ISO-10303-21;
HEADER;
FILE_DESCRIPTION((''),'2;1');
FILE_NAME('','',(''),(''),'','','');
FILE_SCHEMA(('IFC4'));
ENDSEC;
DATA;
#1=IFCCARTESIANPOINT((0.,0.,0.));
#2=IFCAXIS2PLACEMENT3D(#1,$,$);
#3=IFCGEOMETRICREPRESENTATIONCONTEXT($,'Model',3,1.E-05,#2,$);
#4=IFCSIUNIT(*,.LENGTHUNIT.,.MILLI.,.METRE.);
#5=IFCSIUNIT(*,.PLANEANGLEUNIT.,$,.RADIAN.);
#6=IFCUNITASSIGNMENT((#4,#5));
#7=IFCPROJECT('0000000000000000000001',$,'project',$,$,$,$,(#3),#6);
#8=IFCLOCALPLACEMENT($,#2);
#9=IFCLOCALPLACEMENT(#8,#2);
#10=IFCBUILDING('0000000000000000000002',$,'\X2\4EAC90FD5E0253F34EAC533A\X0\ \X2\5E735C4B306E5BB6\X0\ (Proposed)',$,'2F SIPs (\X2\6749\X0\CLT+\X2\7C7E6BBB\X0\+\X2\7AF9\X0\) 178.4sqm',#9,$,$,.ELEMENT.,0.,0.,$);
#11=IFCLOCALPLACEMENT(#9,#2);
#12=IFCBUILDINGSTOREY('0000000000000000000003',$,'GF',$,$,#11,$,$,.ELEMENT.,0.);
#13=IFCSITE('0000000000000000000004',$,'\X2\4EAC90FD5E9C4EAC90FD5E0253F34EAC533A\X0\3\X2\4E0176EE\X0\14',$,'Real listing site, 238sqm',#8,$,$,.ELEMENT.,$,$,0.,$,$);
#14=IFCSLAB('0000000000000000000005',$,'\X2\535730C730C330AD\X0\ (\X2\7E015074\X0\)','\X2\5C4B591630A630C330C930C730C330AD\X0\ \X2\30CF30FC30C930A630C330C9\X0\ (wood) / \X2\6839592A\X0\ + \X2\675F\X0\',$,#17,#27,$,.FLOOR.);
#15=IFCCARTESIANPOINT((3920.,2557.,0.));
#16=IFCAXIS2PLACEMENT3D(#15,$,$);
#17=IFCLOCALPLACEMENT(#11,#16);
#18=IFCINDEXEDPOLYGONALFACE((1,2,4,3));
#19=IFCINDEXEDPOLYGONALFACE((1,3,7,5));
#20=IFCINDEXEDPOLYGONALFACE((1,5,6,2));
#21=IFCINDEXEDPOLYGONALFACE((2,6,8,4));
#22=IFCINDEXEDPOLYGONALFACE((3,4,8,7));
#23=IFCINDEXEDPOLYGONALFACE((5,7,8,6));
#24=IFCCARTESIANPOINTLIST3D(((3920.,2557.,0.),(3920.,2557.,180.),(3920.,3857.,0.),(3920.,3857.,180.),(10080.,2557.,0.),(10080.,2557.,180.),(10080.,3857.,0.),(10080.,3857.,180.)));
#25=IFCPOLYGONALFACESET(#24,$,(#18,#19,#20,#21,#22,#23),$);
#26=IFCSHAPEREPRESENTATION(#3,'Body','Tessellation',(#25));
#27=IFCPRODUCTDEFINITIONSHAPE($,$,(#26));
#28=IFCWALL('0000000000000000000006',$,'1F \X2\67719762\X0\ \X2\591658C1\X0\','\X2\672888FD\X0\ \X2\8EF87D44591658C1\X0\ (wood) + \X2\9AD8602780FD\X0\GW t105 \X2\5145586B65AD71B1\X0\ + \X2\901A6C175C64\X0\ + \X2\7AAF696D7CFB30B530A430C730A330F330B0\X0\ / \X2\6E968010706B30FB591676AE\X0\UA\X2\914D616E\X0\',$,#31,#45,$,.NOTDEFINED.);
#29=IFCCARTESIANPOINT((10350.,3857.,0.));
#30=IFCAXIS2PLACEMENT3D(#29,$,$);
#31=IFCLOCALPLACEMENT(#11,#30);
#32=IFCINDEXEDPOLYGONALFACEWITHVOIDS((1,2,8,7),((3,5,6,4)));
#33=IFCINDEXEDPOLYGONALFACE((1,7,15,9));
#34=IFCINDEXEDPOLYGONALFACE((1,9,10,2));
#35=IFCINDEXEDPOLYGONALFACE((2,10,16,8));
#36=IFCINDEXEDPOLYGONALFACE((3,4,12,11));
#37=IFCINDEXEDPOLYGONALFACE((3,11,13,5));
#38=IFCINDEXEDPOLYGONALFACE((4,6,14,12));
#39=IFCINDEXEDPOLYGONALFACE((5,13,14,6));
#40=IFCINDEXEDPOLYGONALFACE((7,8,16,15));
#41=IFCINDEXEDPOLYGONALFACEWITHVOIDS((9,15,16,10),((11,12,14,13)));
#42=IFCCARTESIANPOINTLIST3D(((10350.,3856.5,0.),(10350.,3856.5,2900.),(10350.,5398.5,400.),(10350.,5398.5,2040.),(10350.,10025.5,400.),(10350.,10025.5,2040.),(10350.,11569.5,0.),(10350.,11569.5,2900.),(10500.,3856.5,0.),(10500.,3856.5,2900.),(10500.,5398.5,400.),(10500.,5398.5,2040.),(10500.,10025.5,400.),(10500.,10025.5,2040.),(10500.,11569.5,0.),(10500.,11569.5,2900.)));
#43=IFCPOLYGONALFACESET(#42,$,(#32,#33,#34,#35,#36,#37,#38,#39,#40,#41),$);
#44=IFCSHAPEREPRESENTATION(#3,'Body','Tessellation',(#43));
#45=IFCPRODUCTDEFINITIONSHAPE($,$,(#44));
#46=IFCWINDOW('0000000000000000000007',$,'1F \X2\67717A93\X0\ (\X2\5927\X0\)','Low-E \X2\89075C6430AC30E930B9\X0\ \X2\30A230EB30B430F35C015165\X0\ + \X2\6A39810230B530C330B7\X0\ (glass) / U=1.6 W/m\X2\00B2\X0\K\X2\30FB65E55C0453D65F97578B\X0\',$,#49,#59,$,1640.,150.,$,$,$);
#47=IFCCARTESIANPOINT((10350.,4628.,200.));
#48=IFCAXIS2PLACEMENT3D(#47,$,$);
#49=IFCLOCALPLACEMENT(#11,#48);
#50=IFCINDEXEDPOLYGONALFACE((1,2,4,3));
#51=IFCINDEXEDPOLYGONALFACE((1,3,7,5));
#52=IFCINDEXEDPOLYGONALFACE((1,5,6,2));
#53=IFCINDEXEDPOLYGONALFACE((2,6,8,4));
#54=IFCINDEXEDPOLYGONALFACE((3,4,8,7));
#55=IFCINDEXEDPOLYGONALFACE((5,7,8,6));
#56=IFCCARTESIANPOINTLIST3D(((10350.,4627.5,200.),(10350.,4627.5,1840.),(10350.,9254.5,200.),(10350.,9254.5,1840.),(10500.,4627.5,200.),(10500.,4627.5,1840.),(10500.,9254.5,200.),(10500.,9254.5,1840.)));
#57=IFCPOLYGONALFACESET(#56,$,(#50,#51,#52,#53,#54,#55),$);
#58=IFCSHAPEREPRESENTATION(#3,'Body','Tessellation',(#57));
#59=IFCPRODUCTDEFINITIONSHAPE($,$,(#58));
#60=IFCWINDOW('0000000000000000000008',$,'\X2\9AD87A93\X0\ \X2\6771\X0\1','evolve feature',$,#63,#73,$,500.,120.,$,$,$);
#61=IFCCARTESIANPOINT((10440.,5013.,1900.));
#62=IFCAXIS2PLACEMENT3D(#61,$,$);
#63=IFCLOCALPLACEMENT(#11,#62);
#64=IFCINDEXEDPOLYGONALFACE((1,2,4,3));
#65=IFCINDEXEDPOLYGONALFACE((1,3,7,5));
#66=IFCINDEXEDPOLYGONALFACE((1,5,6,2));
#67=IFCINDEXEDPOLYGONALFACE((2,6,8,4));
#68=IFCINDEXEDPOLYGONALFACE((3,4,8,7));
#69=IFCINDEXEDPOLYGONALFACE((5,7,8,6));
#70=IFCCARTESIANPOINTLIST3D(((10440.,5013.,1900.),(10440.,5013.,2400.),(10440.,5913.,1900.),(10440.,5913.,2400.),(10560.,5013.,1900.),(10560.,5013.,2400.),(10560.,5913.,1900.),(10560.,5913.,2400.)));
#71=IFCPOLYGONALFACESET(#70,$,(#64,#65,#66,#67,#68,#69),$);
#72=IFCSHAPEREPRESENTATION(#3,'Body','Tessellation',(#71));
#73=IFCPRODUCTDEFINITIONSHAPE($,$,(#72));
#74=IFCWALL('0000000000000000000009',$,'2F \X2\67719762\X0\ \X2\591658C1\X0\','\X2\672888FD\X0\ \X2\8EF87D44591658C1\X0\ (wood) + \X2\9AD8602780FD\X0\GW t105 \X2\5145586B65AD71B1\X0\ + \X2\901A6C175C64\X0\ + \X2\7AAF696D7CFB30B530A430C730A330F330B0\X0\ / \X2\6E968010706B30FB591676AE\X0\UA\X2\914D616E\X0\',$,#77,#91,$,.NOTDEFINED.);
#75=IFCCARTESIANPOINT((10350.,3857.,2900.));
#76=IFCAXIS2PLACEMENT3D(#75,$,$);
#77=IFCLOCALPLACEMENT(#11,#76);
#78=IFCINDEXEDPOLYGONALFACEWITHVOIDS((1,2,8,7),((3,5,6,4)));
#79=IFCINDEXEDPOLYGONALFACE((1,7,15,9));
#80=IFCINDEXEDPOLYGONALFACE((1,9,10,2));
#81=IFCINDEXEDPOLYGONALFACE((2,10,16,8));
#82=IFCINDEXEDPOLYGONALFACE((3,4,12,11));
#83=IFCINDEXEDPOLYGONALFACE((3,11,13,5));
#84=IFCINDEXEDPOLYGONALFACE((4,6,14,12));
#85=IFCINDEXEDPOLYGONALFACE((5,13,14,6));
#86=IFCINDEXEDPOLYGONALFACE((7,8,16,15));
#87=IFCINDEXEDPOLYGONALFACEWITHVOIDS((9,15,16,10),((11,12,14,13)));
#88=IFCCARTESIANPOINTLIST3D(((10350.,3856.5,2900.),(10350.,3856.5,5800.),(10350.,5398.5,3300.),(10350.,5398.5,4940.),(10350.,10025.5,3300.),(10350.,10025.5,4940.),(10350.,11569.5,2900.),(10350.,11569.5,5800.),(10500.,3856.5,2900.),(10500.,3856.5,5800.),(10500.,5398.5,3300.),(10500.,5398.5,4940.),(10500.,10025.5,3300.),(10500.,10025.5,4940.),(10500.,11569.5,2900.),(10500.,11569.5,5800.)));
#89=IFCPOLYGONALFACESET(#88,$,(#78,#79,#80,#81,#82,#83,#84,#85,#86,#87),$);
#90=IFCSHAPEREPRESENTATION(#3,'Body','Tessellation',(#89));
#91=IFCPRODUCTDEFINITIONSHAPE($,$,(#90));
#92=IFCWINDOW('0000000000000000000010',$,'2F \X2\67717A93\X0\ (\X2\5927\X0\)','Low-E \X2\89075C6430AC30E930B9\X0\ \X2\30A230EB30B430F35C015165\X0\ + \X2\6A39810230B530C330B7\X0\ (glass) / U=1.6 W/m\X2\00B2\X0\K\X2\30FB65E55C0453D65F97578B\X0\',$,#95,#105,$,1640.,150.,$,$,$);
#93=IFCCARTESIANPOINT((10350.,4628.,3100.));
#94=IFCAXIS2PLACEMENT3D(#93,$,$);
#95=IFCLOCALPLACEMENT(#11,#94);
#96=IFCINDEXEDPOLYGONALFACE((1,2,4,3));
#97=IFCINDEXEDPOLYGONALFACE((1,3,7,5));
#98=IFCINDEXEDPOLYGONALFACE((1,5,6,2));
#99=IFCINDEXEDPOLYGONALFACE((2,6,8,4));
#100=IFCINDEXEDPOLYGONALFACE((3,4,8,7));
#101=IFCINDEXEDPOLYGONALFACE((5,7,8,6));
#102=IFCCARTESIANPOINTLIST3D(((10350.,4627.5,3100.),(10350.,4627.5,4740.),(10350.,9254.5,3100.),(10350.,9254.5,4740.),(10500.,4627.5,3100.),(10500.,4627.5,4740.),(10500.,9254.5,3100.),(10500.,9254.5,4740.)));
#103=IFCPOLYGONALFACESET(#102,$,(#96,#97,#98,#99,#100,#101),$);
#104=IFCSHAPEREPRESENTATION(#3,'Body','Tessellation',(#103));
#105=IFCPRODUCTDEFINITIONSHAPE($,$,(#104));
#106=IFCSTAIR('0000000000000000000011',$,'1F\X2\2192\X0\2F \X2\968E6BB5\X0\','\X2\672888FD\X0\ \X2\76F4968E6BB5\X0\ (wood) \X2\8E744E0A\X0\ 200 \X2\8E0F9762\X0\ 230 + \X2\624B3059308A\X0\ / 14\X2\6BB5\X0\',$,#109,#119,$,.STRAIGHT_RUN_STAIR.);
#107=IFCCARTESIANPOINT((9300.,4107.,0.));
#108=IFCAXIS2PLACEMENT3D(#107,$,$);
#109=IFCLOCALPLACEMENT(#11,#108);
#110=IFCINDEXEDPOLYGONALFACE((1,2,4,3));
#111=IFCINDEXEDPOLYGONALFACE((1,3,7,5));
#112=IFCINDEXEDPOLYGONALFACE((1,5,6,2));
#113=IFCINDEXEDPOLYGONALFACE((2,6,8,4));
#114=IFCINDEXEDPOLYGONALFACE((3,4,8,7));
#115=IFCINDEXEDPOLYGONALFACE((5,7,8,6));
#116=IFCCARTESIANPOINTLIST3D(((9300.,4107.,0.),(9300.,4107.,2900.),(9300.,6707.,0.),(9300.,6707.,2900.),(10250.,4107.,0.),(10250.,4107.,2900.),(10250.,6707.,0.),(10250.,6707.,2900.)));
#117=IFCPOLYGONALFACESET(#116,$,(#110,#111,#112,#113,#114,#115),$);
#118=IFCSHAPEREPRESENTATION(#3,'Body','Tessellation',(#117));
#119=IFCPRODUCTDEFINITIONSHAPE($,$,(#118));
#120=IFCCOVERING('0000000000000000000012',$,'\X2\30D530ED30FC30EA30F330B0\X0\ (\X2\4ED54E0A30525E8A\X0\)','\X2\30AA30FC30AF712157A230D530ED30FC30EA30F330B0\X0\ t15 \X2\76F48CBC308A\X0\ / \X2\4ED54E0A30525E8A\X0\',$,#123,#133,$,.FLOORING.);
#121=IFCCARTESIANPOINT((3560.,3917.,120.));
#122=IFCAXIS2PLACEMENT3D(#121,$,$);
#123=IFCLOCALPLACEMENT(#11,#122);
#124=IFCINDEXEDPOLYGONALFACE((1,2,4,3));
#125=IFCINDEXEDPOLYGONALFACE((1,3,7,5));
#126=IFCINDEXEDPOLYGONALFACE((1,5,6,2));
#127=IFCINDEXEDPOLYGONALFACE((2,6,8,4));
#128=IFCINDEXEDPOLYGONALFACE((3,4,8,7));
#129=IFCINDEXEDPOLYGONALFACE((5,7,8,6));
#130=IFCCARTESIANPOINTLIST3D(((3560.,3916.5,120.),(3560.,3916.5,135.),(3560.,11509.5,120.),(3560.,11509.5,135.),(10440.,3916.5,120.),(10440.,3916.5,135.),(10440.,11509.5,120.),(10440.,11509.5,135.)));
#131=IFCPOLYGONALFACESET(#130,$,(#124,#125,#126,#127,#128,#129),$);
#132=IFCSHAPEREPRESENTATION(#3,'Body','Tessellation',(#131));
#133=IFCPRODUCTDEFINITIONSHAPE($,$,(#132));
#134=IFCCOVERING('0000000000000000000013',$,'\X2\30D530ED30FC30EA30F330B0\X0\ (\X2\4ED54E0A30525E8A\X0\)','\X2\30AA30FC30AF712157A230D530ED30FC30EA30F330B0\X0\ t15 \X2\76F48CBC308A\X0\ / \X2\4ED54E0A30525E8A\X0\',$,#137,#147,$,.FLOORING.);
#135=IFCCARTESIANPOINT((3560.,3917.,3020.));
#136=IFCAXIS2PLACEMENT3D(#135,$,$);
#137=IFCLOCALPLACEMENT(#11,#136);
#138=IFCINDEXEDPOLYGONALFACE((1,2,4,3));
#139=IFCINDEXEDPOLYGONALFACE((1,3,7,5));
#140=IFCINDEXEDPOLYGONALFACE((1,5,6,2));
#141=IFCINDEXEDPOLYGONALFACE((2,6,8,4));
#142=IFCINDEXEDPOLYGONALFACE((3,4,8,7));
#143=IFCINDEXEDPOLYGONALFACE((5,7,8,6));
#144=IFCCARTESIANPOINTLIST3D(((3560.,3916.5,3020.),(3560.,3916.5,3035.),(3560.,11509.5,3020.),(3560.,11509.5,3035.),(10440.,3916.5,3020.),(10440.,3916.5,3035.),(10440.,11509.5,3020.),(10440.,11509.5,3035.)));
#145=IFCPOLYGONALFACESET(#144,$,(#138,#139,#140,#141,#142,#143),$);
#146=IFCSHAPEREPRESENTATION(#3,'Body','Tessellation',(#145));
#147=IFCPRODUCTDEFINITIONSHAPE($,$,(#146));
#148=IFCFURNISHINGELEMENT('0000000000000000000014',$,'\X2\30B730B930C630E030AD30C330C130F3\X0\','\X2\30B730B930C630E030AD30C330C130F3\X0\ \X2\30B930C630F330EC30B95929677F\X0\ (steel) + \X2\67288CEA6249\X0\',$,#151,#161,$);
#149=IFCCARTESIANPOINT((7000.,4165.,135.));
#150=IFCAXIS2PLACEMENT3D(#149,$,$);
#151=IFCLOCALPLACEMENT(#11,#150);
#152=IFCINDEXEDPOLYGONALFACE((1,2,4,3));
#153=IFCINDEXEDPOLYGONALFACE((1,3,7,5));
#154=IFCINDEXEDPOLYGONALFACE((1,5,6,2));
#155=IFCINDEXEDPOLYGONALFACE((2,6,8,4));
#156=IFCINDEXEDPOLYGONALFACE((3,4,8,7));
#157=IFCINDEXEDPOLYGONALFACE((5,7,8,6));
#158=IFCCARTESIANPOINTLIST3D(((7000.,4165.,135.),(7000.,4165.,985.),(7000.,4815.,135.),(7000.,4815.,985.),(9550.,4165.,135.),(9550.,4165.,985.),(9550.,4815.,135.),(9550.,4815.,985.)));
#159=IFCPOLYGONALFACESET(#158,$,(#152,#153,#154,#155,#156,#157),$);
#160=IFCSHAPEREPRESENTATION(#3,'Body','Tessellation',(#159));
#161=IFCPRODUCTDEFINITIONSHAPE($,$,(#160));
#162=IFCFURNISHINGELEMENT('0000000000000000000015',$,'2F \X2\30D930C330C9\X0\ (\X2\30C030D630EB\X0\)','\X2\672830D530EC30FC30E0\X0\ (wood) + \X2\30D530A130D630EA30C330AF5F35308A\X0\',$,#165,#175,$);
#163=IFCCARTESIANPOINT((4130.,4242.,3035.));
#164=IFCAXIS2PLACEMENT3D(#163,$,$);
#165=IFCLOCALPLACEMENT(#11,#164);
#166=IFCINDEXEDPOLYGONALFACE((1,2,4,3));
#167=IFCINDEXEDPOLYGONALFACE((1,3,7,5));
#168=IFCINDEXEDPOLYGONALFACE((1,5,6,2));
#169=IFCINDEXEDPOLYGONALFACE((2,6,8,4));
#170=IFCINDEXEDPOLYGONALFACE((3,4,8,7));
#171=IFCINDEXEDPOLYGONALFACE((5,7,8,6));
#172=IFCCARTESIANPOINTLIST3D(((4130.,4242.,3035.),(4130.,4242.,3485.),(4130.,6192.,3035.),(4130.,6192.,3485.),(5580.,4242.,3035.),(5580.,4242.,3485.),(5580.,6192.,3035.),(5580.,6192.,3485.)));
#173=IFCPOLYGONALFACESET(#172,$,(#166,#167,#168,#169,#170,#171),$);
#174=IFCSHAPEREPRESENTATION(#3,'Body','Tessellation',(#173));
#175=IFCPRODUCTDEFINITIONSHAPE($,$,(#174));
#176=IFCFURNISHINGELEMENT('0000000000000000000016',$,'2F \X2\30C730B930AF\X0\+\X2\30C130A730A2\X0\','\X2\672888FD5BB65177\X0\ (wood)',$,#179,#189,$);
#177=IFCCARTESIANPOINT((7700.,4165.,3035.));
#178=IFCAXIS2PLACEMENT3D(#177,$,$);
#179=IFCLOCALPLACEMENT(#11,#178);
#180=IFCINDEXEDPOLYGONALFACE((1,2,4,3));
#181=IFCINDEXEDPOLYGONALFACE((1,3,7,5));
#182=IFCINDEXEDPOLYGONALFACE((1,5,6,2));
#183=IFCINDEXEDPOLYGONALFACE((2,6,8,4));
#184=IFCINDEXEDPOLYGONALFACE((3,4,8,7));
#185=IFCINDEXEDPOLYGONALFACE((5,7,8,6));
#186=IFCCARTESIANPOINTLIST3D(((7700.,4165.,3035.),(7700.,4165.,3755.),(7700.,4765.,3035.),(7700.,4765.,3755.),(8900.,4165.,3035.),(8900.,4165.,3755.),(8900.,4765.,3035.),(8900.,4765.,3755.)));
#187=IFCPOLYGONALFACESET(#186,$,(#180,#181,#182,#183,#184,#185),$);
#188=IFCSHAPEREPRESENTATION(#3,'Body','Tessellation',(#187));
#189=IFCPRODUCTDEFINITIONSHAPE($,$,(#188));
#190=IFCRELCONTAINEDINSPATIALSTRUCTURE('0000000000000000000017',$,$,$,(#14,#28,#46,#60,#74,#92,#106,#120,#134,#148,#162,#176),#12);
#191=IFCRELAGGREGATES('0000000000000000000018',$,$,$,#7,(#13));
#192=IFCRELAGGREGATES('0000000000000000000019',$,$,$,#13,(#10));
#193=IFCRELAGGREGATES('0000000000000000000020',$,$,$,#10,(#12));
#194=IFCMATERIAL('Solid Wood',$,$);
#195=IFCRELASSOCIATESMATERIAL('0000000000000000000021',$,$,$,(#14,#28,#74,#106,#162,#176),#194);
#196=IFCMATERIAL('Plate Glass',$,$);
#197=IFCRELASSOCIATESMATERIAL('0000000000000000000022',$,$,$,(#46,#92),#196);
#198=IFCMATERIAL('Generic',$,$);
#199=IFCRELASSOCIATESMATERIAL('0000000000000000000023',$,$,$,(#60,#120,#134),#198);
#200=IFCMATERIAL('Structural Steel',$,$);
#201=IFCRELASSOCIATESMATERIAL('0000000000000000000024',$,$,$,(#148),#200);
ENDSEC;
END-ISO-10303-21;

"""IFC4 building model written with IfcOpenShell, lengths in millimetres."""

from ifc_helpers import new_model, si_unit, frame, frame_2d, origin, place, context, project, spatial, rectangle, extrude, material, element, fill, save


model = new_model("IFC4")

# Units and contexts
model_context = context("Model", 3, precision=1e-05, world=origin())
ifc_project = project(units=[si_unit("LENGTHUNIT", "METRE", prefix="MILLI"), si_unit("PLANEANGLEUNIT", "RADIAN")], contexts=[model_context])

# Site, building, storey
site_placement = place(None, origin())
site = spatial("IfcSite", under=ifc_project, at=site_placement, Name="京都府京都市右京区3丁目14", ObjectType="Real listing site, 238sqm", CompositionType="ELEMENT", RefElevation=0.0)
building_placement = place(site_placement, origin())
building = spatial("IfcBuilding", under=site, at=building_placement, Name="京都市右京区 平屋の家 (Proposed)", ObjectType="2F SIPs (杉CLT+籾殻+竹) 178.4sqm", CompositionType="ELEMENT", ElevationOfRefHeight=0.0, ElevationOfTerrain=0.0)
storey_placement = place(building_placement, origin())
storey = spatial("IfcBuildingStorey", under=building, at=storey_placement, Name="GF", CompositionType="ELEMENT", Elevation=0.0)

# Slab
ifc_material_1 = material(Name="Solid Wood")
slab_placement = place(storey_placement, frame((3920.0, 2557.0, 0.0)))
element("IfcSlab", 1, at=slab_placement, inside=storey, material=ifc_material_1, Name="南デッキ (縁側)", Description="屋外ウッドデッキ ハードウッド (wood) / 根太 + 束", PredefinedType="FLOOR", context=model_context, shape_type="SweptSolid", body=[
    extrude(rectangle(XDim=6160.0, YDim=1300.0, at=frame_2d((3080.0, 650.0))), frame((3920.0, 2557.0, 0.0)), (0.0, 0.0, 1.0), 180.0),
])

# Wall, openings, windows
wall_1_placement = place(storey_placement, frame((10350.0, 3857.0, 0.0)))
wall_1 = element("IfcWall", 2, at=wall_1_placement, inside=storey, material=ifc_material_1, Name="1F 東面 外壁", Description="木製 軸組外壁 (wood) + 高性能GW t105 充填断熱 + 通気層 + 窯業系サイディング / 準耐火・外皮UA配慮", PredefinedType="NOTDEFINED", context=model_context, shape_type="SweptSolid", body=[
    extrude(rectangle(XDim=150.0, YDim=7713.0, at=frame_2d((75.0, 3856.0))), frame((10350.0, 3857.0, 0.0)), (0.0, 0.0, 1.0), 2900.0),
])
opening_1_placement = place(storey_placement, frame((10350.0, 4628.0, 200.0)))
opening_1 = element("IfcOpeningElement", 3, at=opening_1_placement, cuts=wall_1, PredefinedType="NOTDEFINED", context=model_context, shape_type="SweptSolid", body=[
    extrude(rectangle(XDim=150.0, YDim=4627.0, at=frame_2d((75.0, 2313.0))), frame((10350.0, 4628.0, 200.0)), (0.0, 0.0, 1.0), 1640.0),
])
opening_2_placement = place(storey_placement, frame((10440.0, 5013.0, 1900.0)))
opening_2 = element("IfcOpeningElement", 4, at=opening_2_placement, cuts=wall_1, PredefinedType="NOTDEFINED", context=model_context, shape_type="SweptSolid", body=[
    extrude(rectangle(XDim=120.0, YDim=900.0, at=frame_2d((60.0, 450.0))), frame((10440.0, 5013.0, 1900.0)), (0.0, 0.0, 1.0), 500.0),
])
ifc_material_2 = material(Name="Plate Glass")
window_1_placement = place(storey_placement, frame((10350.0, 4628.0, 200.0)))
window_1 = element("IfcWindow", 5, at=window_1_placement, inside=storey, material=ifc_material_2, Name="1F 東窓 (大)", Description="Low-E 複層ガラス アルゴン封入 + 樹脂サッシ (glass) / U=1.6 W/m²K・日射取得型", OverallHeight=1640.0, OverallWidth=150.0, context=model_context, shape_type="SweptSolid", body=[
    extrude(rectangle(XDim=150.0, YDim=4627.0, at=frame_2d((75.0, 2313.0))), frame((10350.0, 4628.0, 200.0)), (0.0, 0.0, 1.0), 1640.0),
])
fill(opening_1, window_1)
ifc_material_3 = material(Name="Generic")
window_2_placement = place(storey_placement, frame((10440.0, 5013.0, 1900.0)))
window_2 = element("IfcWindow", 6, at=window_2_placement, inside=storey, material=ifc_material_3, Name="高窓 東1", Description="evolve feature", OverallHeight=500.0, OverallWidth=120.0, context=model_context, shape_type="SweptSolid", body=[
    extrude(rectangle(XDim=120.0, YDim=900.0, at=frame_2d((60.0, 450.0))), frame((10440.0, 5013.0, 1900.0)), (0.0, 0.0, 1.0), 500.0),
])
fill(opening_2, window_2)

# Wall, opening, window
wall_2_placement = place(storey_placement, frame((10350.0, 3857.0, 2900.0)))
wall_2 = element("IfcWall", 7, at=wall_2_placement, inside=storey, material=ifc_material_1, Name="2F 東面 外壁", Description="木製 軸組外壁 (wood) + 高性能GW t105 充填断熱 + 通気層 + 窯業系サイディング / 準耐火・外皮UA配慮", PredefinedType="NOTDEFINED", context=model_context, shape_type="SweptSolid", body=[
    extrude(rectangle(XDim=150.0, YDim=7713.0, at=frame_2d((75.0, 3856.0))), frame((10350.0, 3857.0, 2900.0)), (0.0, 0.0, 1.0), 2900.0),
])
opening_3_placement = place(storey_placement, frame((10350.0, 4628.0, 3100.0)))
opening_3 = element("IfcOpeningElement", 8, at=opening_3_placement, cuts=wall_2, PredefinedType="NOTDEFINED", context=model_context, shape_type="SweptSolid", body=[
    extrude(rectangle(XDim=150.0, YDim=4627.0, at=frame_2d((75.0, 2313.0))), frame((10350.0, 4628.0, 3100.0)), (0.0, 0.0, 1.0), 1640.0),
])
window_3_placement = place(storey_placement, frame((10350.0, 4628.0, 3100.0)))
window_3 = element("IfcWindow", 9, at=window_3_placement, inside=storey, material=ifc_material_2, Name="2F 東窓 (大)", Description="Low-E 複層ガラス アルゴン封入 + 樹脂サッシ (glass) / U=1.6 W/m²K・日射取得型", OverallHeight=1640.0, OverallWidth=150.0, context=model_context, shape_type="SweptSolid", body=[
    extrude(rectangle(XDim=150.0, YDim=4627.0, at=frame_2d((75.0, 2313.0))), frame((10350.0, 4628.0, 3100.0)), (0.0, 0.0, 1.0), 1640.0),
])
fill(opening_3, window_3)

# Stair
stair_placement = place(storey_placement, frame((9300.0, 4107.0, 0.0)))
element("IfcStair", 10, at=stair_placement, inside=storey, material=ifc_material_1, Name="1F→2F 階段", Description="木製 直階段 (wood) 蹴上 200 踏面 230 + 手すり / 14段", PredefinedType="STRAIGHT_RUN_STAIR", context=model_context, shape_type="SweptSolid", body=[
    extrude(rectangle(XDim=950.0, YDim=2600.0, at=frame_2d((475.0, 1300.0))), frame((9300.0, 4107.0, 0.0)), (0.0, 0.0, 1.0), 2900.0),
])

# Coverings
covering_1_placement = place(storey_placement, frame((3560.0, 3917.0, 120.0)))
element("IfcCovering", 11, at=covering_1_placement, inside=storey, material=ifc_material_3, Name="フローリング (仕上げ床)", Description="オーク無垢フローリング t15 直貼り / 仕上げ床", PredefinedType="FLOORING", context=model_context, shape_type="SweptSolid", body=[
    extrude(rectangle(XDim=6880.0, YDim=7593.0, at=frame_2d((3440.0, 3796.0))), frame((3560.0, 3917.0, 120.0)), (0.0, 0.0, 1.0), 15.0),
])
covering_2_placement = place(storey_placement, frame((3560.0, 3917.0, 3020.0)))
element("IfcCovering", 12, at=covering_2_placement, inside=storey, material=ifc_material_3, Name="フローリング (仕上げ床)", Description="オーク無垢フローリング t15 直貼り / 仕上げ床", PredefinedType="FLOORING", context=model_context, shape_type="SweptSolid", body=[
    extrude(rectangle(XDim=6880.0, YDim=7593.0, at=frame_2d((3440.0, 3796.0))), frame((3560.0, 3917.0, 3020.0)), (0.0, 0.0, 1.0), 15.0),
])

# Furnishing elements
ifc_material_4 = material(Name="Structural Steel")
furnishing_1_placement = place(storey_placement, frame((7000.0, 4165.0, 135.0)))
element("IfcFurnishingElement", 13, at=furnishing_1_placement, inside=storey, material=ifc_material_4, Name="システムキッチン", Description="システムキッチン ステンレス天板 (steel) + 木質扉", context=model_context, shape_type="SweptSolid", body=[
    extrude(rectangle(XDim=2550.0, YDim=650.0, at=frame_2d((1275.0, 325.0))), frame((7000.0, 4165.0, 135.0)), (0.0, 0.0, 1.0), 850.0),
])
furnishing_2_placement = place(storey_placement, frame((4130.0, 4242.0, 3035.0)))
element("IfcFurnishingElement", 14, at=furnishing_2_placement, inside=storey, material=ifc_material_1, Name="2F ベッド (ダブル)", Description="木フレーム (wood) + ファブリック張り", context=model_context, shape_type="SweptSolid", body=[
    extrude(rectangle(XDim=1450.0, YDim=1950.0, at=frame_2d((725.0, 975.0))), frame((4130.0, 4242.0, 3035.0)), (0.0, 0.0, 1.0), 450.0),
])
furnishing_3_placement = place(storey_placement, frame((7700.0, 4165.0, 3035.0)))
element("IfcFurnishingElement", 15, at=furnishing_3_placement, inside=storey, material=ifc_material_1, Name="2F デスク+チェア", Description="木製家具 (wood)", context=model_context, shape_type="SweptSolid", body=[
    extrude(rectangle(XDim=1200.0, YDim=600.0, at=frame_2d((600.0, 300.0))), frame((7700.0, 4165.0, 3035.0)), (0.0, 0.0, 1.0), 720.0),
])

save(model, "model.ifc")
